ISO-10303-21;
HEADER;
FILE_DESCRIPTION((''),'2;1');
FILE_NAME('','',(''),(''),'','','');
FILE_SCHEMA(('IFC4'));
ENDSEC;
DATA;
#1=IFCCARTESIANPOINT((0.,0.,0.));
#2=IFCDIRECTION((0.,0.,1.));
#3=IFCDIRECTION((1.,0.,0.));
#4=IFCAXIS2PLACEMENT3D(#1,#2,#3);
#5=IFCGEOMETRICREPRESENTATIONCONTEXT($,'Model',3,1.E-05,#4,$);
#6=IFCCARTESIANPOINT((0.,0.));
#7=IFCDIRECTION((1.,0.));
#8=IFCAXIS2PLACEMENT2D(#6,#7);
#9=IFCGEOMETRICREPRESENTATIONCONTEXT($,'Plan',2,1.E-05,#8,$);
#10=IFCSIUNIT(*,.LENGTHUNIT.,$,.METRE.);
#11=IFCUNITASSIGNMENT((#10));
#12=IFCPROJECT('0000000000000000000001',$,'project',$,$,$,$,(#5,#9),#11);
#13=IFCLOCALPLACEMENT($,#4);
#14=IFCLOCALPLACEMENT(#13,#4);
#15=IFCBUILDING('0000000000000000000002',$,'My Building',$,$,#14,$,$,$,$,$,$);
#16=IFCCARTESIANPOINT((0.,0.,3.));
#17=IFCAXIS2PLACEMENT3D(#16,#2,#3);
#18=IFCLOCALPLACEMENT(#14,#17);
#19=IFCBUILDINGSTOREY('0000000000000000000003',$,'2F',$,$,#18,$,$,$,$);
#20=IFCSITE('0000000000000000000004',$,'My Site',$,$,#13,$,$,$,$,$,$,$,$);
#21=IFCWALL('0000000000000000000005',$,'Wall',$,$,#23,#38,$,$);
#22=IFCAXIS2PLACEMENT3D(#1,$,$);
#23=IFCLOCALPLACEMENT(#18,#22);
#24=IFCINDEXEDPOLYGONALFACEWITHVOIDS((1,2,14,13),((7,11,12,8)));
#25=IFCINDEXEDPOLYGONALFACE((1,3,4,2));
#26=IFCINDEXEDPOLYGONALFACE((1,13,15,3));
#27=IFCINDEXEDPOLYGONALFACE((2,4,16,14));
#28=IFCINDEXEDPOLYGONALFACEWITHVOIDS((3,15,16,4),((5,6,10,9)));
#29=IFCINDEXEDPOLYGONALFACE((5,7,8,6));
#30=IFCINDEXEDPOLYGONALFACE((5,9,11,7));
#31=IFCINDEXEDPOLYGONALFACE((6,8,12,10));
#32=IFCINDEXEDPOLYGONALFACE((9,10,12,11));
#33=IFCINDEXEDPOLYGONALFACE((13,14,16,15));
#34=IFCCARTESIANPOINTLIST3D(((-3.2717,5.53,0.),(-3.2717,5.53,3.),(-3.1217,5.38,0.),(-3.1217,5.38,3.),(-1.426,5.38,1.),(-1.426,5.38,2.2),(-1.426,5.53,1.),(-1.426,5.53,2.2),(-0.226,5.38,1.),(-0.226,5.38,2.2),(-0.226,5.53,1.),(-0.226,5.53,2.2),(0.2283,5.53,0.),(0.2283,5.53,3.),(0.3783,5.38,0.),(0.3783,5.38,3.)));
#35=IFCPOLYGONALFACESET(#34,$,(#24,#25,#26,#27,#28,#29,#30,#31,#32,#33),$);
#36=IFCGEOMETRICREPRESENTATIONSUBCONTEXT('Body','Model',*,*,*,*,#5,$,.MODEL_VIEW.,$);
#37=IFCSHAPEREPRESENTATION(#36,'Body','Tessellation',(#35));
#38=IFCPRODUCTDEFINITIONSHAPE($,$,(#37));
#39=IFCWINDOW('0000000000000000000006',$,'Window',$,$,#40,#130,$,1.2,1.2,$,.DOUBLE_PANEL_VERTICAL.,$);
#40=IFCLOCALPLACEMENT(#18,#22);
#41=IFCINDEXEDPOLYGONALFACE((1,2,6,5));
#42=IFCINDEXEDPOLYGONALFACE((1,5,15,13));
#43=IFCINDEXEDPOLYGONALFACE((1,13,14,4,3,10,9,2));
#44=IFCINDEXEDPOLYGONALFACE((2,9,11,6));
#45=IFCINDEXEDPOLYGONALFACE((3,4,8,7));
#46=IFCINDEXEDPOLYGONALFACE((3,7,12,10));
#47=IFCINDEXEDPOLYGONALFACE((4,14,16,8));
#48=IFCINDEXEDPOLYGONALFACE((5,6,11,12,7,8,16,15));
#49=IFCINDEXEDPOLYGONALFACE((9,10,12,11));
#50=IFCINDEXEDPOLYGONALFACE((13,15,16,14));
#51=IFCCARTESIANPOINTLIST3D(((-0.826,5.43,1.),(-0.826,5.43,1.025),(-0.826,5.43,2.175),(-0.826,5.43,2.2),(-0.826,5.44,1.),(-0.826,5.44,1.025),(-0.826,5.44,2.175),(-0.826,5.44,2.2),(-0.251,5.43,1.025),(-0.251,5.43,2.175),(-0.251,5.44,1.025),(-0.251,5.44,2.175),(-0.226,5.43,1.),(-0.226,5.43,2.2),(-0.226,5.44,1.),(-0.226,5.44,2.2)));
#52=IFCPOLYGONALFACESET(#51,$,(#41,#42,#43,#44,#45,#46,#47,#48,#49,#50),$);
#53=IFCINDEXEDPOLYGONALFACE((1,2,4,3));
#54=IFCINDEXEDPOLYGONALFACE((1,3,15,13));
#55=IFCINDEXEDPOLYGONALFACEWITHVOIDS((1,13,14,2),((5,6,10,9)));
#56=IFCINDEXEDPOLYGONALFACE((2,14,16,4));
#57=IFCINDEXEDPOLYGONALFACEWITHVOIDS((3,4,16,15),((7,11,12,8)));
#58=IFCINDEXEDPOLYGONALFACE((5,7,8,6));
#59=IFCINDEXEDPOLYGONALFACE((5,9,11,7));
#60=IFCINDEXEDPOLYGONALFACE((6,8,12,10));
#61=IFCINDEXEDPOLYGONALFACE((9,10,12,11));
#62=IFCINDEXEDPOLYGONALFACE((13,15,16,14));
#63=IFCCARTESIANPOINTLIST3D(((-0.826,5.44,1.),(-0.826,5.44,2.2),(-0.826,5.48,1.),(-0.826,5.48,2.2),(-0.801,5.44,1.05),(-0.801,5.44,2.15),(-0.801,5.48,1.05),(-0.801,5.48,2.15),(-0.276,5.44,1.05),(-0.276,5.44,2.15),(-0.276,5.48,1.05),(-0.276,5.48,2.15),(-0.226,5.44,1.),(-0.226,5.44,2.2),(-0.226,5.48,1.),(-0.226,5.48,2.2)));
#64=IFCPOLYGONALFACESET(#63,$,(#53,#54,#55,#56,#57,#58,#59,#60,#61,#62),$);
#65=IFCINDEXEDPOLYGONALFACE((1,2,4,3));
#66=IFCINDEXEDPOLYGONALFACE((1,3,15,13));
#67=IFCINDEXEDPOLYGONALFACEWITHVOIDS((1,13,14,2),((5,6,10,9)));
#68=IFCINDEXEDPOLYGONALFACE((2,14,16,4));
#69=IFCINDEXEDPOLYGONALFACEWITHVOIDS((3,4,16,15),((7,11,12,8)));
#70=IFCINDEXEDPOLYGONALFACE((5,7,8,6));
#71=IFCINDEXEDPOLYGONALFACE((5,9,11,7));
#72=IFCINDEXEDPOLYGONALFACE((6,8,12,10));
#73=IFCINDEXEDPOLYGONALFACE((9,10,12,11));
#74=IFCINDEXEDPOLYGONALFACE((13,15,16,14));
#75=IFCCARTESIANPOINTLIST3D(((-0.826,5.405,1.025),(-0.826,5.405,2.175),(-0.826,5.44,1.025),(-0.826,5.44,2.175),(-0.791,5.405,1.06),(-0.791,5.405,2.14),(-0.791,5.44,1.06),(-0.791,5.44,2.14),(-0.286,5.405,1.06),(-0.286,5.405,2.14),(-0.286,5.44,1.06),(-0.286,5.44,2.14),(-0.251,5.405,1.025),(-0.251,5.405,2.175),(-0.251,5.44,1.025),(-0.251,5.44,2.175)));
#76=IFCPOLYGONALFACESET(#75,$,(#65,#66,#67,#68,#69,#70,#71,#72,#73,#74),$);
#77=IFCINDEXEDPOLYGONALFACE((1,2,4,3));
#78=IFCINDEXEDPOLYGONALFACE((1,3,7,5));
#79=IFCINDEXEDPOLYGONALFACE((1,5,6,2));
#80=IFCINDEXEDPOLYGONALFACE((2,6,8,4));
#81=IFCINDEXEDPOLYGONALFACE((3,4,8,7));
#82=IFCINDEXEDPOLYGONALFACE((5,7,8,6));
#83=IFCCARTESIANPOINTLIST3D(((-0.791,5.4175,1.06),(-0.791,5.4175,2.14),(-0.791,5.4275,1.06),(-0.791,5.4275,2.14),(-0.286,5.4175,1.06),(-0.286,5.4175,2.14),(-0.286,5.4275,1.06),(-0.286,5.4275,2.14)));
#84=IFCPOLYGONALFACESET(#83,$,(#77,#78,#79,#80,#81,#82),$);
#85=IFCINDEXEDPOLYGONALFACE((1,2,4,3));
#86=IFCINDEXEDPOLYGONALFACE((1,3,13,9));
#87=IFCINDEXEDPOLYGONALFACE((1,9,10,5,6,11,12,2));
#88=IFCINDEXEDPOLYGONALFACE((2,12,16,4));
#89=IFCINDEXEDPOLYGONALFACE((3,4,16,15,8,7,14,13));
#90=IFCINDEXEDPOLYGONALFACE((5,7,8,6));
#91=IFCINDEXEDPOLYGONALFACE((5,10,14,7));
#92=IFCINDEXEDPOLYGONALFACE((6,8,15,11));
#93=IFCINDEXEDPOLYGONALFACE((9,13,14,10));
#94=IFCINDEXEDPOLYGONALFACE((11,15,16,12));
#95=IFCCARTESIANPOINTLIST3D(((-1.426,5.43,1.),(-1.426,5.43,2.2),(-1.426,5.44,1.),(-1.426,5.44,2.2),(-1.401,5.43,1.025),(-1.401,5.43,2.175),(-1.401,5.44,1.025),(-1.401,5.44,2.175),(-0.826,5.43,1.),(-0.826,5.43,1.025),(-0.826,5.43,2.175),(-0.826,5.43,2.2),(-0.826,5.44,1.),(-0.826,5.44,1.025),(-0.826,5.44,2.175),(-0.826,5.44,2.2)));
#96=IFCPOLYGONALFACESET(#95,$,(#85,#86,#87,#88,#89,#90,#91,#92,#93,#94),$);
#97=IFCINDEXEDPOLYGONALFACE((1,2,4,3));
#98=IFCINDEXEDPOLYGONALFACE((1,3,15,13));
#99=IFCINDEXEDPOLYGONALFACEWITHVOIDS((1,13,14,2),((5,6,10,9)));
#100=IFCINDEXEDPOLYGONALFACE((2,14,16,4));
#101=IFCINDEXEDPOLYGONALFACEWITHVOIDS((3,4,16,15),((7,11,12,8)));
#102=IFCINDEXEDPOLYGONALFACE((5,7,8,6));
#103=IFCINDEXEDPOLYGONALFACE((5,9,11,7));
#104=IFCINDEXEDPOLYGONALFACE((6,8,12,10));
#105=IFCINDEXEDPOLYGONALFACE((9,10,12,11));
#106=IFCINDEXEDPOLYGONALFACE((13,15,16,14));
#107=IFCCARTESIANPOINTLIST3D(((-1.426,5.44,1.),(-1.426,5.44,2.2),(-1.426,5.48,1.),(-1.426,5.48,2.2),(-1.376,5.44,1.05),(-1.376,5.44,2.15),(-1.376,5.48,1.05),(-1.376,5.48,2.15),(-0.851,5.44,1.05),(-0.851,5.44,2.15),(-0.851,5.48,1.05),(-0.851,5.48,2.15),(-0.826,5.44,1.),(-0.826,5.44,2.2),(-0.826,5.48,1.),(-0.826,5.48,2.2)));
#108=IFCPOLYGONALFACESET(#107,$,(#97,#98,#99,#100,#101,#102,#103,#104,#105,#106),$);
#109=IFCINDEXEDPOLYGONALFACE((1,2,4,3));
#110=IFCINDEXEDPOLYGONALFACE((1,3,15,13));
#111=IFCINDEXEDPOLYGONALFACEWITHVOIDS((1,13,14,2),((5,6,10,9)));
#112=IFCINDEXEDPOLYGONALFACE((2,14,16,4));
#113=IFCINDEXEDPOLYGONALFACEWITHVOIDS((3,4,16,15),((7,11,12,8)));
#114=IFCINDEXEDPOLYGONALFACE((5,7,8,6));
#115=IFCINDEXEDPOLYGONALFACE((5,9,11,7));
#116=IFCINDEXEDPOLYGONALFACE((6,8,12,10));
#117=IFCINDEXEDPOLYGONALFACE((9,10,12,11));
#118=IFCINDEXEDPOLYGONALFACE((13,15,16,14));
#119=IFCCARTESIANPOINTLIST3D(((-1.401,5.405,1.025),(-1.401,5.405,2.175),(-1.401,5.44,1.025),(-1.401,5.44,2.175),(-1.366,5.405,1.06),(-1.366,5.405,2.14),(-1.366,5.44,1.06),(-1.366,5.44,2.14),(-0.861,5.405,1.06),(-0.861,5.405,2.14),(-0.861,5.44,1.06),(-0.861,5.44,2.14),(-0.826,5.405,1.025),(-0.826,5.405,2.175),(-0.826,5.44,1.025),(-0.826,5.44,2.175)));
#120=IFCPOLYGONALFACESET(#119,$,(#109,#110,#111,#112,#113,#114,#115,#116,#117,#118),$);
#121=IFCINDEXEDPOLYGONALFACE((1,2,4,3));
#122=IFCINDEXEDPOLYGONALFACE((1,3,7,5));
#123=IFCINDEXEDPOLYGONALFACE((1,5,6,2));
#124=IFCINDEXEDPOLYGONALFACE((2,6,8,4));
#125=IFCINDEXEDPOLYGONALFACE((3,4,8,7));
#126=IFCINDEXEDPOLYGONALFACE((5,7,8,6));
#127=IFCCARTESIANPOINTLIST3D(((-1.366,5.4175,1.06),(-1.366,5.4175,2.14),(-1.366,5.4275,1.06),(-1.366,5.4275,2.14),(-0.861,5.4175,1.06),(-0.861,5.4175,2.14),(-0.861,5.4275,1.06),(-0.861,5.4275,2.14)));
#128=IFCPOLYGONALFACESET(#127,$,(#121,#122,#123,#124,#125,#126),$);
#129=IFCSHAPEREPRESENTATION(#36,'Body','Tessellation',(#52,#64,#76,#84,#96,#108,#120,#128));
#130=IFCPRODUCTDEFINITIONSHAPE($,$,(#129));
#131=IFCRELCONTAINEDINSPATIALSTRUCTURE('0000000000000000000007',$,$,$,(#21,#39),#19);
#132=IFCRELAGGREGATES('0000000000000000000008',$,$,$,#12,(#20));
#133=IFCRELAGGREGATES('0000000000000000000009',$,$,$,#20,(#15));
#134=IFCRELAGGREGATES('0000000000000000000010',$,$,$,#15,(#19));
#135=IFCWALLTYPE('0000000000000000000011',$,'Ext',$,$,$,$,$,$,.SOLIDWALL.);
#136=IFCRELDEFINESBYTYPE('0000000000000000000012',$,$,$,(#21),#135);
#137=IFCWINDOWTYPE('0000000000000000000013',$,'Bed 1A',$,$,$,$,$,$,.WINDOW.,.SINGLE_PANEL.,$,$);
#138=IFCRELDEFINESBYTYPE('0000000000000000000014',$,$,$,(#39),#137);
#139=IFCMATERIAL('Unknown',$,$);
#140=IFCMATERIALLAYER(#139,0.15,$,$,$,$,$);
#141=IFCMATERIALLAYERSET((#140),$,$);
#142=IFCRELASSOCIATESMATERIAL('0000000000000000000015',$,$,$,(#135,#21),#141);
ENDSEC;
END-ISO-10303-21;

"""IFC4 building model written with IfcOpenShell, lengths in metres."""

from ifc_helpers import new_model, entity, si_unit, frame, origin_with_axes, origin_2d_with_axis, place, context, subcontext, project, spatial, line, indexed_curve, outline, extrude, shape, source, transform, mapped, material, layer, layer_set, layer_usage, type_object, type_shapes, element, fill, save


model = new_model("IFC4")

# Units and contexts
model_context = context("Model", 3, precision=1e-05, world=origin_with_axes())
plan_context = context("Plan", 2, precision=1e-05, world=origin_2d_with_axis())
body_context_1 = subcontext(model_context, "Body", "Model", "MODEL_VIEW")
body_context_2 = subcontext(plan_context, "Body", "Plan", "PLAN_VIEW")
ifc_project = project(units=[si_unit("LENGTHUNIT", "METRE")], contexts=[model_context, plan_context])

# Site, building, storey
site_placement = place(None, origin_with_axes())
site = spatial("IfcSite", under=ifc_project, at=site_placement, Name="My Site")
building_placement = place(site_placement, origin_with_axes())
building = spatial("IfcBuilding", under=site, at=building_placement, Name="My Building")
storey_placement = place(building_placement, frame((0.0, 0.0, 3.0), z_axis=(0.0, 0.0, 1.0), x_axis=(1.0, 0.0, 0.0)))
storey = spatial("IfcBuildingStorey", under=building, at=storey_placement, Name="2F")

# Shared definitions
ifc_material = material(Name="Unknown")
ifc_layer_1 = layer(ifc_material, 0.15)
ifc_layer_set_1 = layer_set([ifc_layer_1])
wall_type_1 = type_object("IfcWallType", Name="Ext", PredefinedType="SOLIDWALL", material=ifc_layer_set_1)

# Wall, opening, window
ifc_layer_usage_1 = layer_usage(ifc_layer_set_1, "AXIS2", "POSITIVE", 0.0)
wall_1_placement = place(storey_placement, frame((0.2283, 5.53, 0.0), z_axis=(0.0, 0.0, 1.0), x_axis=(-1.0, 0.0, 0.0)))
wall_1 = element("IfcWall", 1, at=wall_1_placement, inside=storey, type_object=wall_type_1, material=ifc_layer_usage_1, Name="Wall", context=body_context_1, shape_type="SweptSolid", body=[
    extrude(outline(indexed_curve([(0.0, 0.0), (-0.15, 0.15), (3.35, 0.15), (3.5, 0.0)], segments=[line(1, 2, 3, 4, 1)])), origin_with_axes(), (0.0, 0.0, 1.0), 3.0),
])
shared_shape_1 = source(origin_with_axes(), body_context_1, "Body", "SweptSolid", [
    extrude(outline(indexed_curve([(0.0, 0.0), (1.2, 0.0), (1.2, 1.2), (0.0, 1.2)], segments=[line(1, 2, 3, 4, 1)])), frame((0.0, -0.6, 0.0), z_axis=(0.0, -1.0, 0.0), x_axis=(1.0, 0.0, 0.0)), (0.0, 0.0, -1.0), 1.2),
])
opening_1_placement = place(wall_1_placement, frame((0.4544, 0.0, 1.0), z_axis=(0.0, 0.0, 1.0), x_axis=(1.0, 0.0, 0.0)))
opening_1 = element("IfcOpeningElement", 2, at=opening_1_placement, cuts=wall_1, PredefinedType="OPENING", context=body_context_1, shape_type="MappedRepresentation", body=[
    mapped(shared_shape_1, transform((0.0, 0.0, 0.0), x_axis=(1.0, 0.0, 0.0), y_axis=(0.0, 1.0, 0.0), z_axis=(0.0, 0.0, 1.0), scale=1.0)),
])
window_type_1 = type_object("IfcWindowType", Name="Bed 1A", PartitioningType="SINGLE_PANEL", PredefinedType="WINDOW")
shared_shape_2 = source(origin_with_axes(), body_context_1, "Body", "SweptSolid", [
    extrude(outline(indexed_curve([(0.6, 0.0), (0.0, 0.0), (0.0, 1.2), (0.6, 1.2), (0.6, 1.175), (0.025, 1.175), (0.025, 0.025), (0.6, 0.025)], segments=[line(1, 2, 3, 4, 5, 6, 7, 8, 1)])), frame((0.0, 0.09, 0.0), z_axis=(0.0, -1.0, 0.0), x_axis=(1.0, 0.0, 0.0)), (0.0, 0.0, -1.0), 0.01),
    extrude(outline(indexed_curve([(0.0, 0.0), (0.6, 0.0), (0.6, 1.2), (0.0, 1.2)], segments=[line(1, 2, 3, 4, 1)]), holes=[indexed_curve([(0.05, 0.05), (0.575, 0.05), (0.575, 1.15), (0.05, 1.15)], segments=[line(1, 2, 3, 4, 1)])]), frame((0.0, 0.05, 0.0), z_axis=(0.0, -1.0, 0.0), x_axis=(1.0, 0.0, 0.0)), (0.0, 0.0, -1.0), 0.04),
    extrude(outline(indexed_curve([(0.0, 0.0), (0.575, 0.0), (0.575, 1.15), (0.0, 1.15)], segments=[line(1, 2, 3, 4, 1)]), holes=[indexed_curve([(0.035, 0.035), (0.54, 0.035), (0.54, 1.115), (0.035, 1.115)], segments=[line(1, 2, 3, 4, 1)])]), frame((0.025, 0.09, 0.025), z_axis=(0.0, -1.0, 0.0), x_axis=(1.0, 0.0, 0.0)), (0.0, 0.0, -1.0), 0.035),
    extrude(outline(indexed_curve([(0.035, 0.035), (0.54, 0.035), (0.54, 1.115), (0.035, 1.115)], segments=[line(1, 2, 3, 4, 1)])), frame((0.025, 0.1025, 0.025), z_axis=(0.0, -1.0, 0.0), x_axis=(1.0, 0.0, 0.0)), (0.0, 0.0, -1.0), 0.01),
    extrude(outline(indexed_curve([(0.0, 1.2), (0.6, 1.2), (0.6, 0.0), (0.0, 0.0), (0.0, 0.025), (0.575, 0.025), (0.575, 1.175), (0.0, 1.175)], segments=[line(1, 2, 3, 4, 5, 6, 7, 8, 1)])), frame((0.6, 0.09, 0.0), z_axis=(0.0, -1.0, 0.0), x_axis=(1.0, 0.0, 0.0)), (0.0, 0.0, -1.0), 0.01),
    extrude(outline(indexed_curve([(0.0, 0.0), (0.6, 0.0), (0.6, 1.2), (0.0, 1.2)], segments=[line(1, 2, 3, 4, 1)]), holes=[indexed_curve([(0.025, 0.05), (0.55, 0.05), (0.55, 1.15), (0.025, 1.15)], segments=[line(1, 2, 3, 4, 1)])]), frame((0.6, 0.05, 0.0), z_axis=(0.0, -1.0, 0.0), x_axis=(1.0, 0.0, 0.0)), (0.0, 0.0, -1.0), 0.04),
    extrude(outline(indexed_curve([(0.0, 0.0), (0.575, 0.0), (0.575, 1.15), (0.0, 1.15)], segments=[line(1, 2, 3, 4, 1)]), holes=[indexed_curve([(0.035, 0.035), (0.54, 0.035), (0.54, 1.115), (0.035, 1.115)], segments=[line(1, 2, 3, 4, 1)])]), frame((0.6, 0.09, 0.025), z_axis=(0.0, -1.0, 0.0), x_axis=(1.0, 0.0, 0.0)), (0.0, 0.0, -1.0), 0.035),
    extrude(outline(indexed_curve([(0.035, 0.035), (0.54, 0.035), (0.54, 1.115), (0.035, 1.115)], segments=[line(1, 2, 3, 4, 1)])), frame((0.6, 0.1025, 0.025), z_axis=(0.0, -1.0, 0.0), x_axis=(1.0, 0.0, 0.0)), (0.0, 0.0, -1.0), 0.01),
])
shared_shape_3 = source(origin_with_axes(), body_context_2, "Body", "Curve2D", [
    entity("IfcIndexedPolyCurve", entity("IfcCartesianPointList2D", [[0.05, 0.05], [0.575, 0.05]])),
    entity("IfcIndexedPolyCurve", entity("IfcCartesianPointList2D", [[0.0, 0.1], [0.025, 0.1], [0.025, 0.09], [0.05, 0.09], [0.05, 0.05], [0.0, 0.05]]), [entity("IfcLineIndex", [1, 2, 3, 4, 5, 6, 1])]),
    entity("IfcIndexedPolyCurve", entity("IfcCartesianPointList2D", [[0.6, 0.1], [0.6, 0.1], [0.6, 0.09], [0.575, 0.09], [0.575, 0.05], [0.6, 0.05]])),
    entity("IfcIndexedPolyCurve", entity("IfcCartesianPointList2D", [[0.025, 0.09], [0.06, 0.09], [0.06, 0.125], [0.025, 0.125]]), [entity("IfcLineIndex", [1, 2, 3, 4, 1])]),
    entity("IfcIndexedPolyCurve", entity("IfcCartesianPointList2D", [[0.6, 0.09], [0.565, 0.09], [0.565, 0.125], [0.6, 0.125]]), [entity("IfcLineIndex", [1, 2, 3, 4, 1])]),
    entity("IfcIndexedPolyCurve", entity("IfcCartesianPointList2D", [[0.06, 0.09], [0.565, 0.09]])),
    entity("IfcIndexedPolyCurve", entity("IfcCartesianPointList2D", [[0.06, 0.125], [0.565, 0.125]])),
    entity("IfcIndexedPolyCurve", entity("IfcCartesianPointList2D", [[0.06, 0.1075], [0.565, 0.1075]])),
    entity("IfcIndexedPolyCurve", entity("IfcCartesianPointList2D", [[0.625, 0.05], [1.15, 0.05]])),
    entity("IfcIndexedPolyCurve", entity("IfcCartesianPointList2D", [[0.6, 0.1], [0.6, 0.1], [0.6, 0.09], [0.625, 0.09], [0.625, 0.05], [0.6, 0.05]])),
    entity("IfcIndexedPolyCurve", entity("IfcCartesianPointList2D", [[1.2, 0.1], [1.175, 0.1], [1.175, 0.09], [1.15, 0.09], [1.15, 0.05], [1.2, 0.05]]), [entity("IfcLineIndex", [1, 2, 3, 4, 5, 6, 1])]),
    entity("IfcIndexedPolyCurve", entity("IfcCartesianPointList2D", [[0.6, 0.09], [0.635, 0.09], [0.635, 0.125], [0.6, 0.125]]), [entity("IfcLineIndex", [1, 2, 3, 4, 1])]),
    entity("IfcIndexedPolyCurve", entity("IfcCartesianPointList2D", [[1.175, 0.09], [1.14, 0.09], [1.14, 0.125], [1.175, 0.125]]), [entity("IfcLineIndex", [1, 2, 3, 4, 1])]),
    entity("IfcIndexedPolyCurve", entity("IfcCartesianPointList2D", [[0.635, 0.09], [1.14, 0.09]])),
    entity("IfcIndexedPolyCurve", entity("IfcCartesianPointList2D", [[0.635, 0.125], [1.14, 0.125]])),
    entity("IfcIndexedPolyCurve", entity("IfcCartesianPointList2D", [[0.635, 0.1075], [1.14, 0.1075]])),
])
type_shapes(window_type_1, [shared_shape_2, shared_shape_3])
window_1_placement = place(opening_1_placement, frame((0.0, 0.0, 0.0), z_axis=(0.0, 0.0, 1.0), x_axis=(1.0, 0.0, 0.0)))
window_1 = element("IfcWindow", 3, at=window_1_placement, inside=storey, type_object=window_type_1, Name="Window", OverallHeight=1.2, OverallWidth=1.2, PartitioningType="DOUBLE_PANEL_VERTICAL", shapes=[
    shape(body_context_1, "Body", "MappedRepresentation", [mapped(shared_shape_2, transform((0.0, 0.0, 0.0), x_axis=(1.0, 0.0, 0.0), y_axis=(0.0, 1.0, 0.0), z_axis=(0.0, 0.0, 1.0), scale=1.0))]),
    shape(body_context_2, "Body", "MappedRepresentation", [mapped(shared_shape_3, transform((0.0, 0.0, 0.0), x_axis=(1.0, 0.0, 0.0), y_axis=(0.0, 1.0, 0.0), z_axis=(0.0, 0.0, 1.0), scale=1.0))]),
])
fill(opening_1, window_1)

save(model, "model.ifc")
